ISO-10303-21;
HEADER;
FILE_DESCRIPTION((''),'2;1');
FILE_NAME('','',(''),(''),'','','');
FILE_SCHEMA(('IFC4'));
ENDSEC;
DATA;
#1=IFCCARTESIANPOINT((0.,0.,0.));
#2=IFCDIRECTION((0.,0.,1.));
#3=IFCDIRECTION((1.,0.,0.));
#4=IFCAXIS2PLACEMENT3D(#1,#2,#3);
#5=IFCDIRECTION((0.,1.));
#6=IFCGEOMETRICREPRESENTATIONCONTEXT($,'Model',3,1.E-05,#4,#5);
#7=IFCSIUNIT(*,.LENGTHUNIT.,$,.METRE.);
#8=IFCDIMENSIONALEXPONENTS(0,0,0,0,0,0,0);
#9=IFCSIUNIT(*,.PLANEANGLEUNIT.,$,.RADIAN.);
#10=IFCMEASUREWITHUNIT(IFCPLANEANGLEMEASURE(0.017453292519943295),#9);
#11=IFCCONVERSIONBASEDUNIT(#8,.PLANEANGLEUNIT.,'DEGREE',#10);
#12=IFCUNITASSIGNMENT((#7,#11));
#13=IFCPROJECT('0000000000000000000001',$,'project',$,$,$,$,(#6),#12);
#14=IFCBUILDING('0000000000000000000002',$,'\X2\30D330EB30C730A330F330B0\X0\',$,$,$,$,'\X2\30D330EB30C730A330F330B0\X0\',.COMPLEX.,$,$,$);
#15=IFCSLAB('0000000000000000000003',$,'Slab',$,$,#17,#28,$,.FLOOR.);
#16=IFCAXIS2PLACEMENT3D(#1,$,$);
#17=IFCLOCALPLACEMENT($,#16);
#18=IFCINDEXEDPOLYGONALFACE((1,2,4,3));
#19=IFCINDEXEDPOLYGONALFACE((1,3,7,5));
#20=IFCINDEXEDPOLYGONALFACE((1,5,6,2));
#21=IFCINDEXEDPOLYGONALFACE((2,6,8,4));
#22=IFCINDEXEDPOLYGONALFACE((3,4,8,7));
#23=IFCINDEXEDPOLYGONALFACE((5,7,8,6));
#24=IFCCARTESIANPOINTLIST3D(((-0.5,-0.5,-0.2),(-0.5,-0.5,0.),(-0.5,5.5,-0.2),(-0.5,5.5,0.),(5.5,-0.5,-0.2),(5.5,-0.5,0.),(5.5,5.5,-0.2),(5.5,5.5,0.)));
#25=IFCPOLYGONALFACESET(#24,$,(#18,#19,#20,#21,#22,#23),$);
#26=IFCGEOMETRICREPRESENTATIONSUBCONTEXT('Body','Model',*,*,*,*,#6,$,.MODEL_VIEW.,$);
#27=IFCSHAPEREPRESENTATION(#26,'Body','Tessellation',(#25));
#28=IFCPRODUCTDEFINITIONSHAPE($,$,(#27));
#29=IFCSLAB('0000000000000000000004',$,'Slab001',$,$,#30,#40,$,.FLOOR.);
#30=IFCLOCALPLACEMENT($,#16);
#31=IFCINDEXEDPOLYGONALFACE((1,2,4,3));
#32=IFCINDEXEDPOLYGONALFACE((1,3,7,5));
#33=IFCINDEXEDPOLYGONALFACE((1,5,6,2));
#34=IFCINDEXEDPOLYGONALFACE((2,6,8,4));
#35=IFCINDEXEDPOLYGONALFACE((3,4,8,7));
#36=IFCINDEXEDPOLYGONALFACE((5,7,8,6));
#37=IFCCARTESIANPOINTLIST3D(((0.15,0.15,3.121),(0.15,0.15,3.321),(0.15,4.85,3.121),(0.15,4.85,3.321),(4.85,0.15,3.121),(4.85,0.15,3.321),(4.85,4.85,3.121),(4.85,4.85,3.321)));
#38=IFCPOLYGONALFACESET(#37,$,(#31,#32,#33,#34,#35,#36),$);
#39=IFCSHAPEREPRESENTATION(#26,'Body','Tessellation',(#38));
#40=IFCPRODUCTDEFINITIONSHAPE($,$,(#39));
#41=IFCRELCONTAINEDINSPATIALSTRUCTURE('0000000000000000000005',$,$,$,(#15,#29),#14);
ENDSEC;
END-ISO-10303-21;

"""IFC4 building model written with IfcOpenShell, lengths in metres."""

from ifc_helpers import new_model, entity, si_unit, converted_unit, direction, frame, origin_with_axes, origin_2d_with_axis, place, context, subcontext, project, spatial, rectangle, extrude, element, save


model = new_model("IFC4")

# Units and contexts
model_context = context("Model", 3, precision=1e-05, world=origin_with_axes(), true_north=direction((0.0, 1.0)))
body_context = subcontext(model_context, "Body", "Model", "MODEL_VIEW")
ifc_project = project(units=[si_unit("LENGTHUNIT", "METRE"), converted_unit("PLANEANGLEUNIT", "DEGREE", entity("IfcPlaneAngleMeasure", 0.017453292519943295), si_unit("PLANEANGLEUNIT", "RADIAN"), dimensions=[0, 0, 0, 0, 0, 0, 0])], contexts=[model_context])

# Building
building = spatial("IfcBuilding", Name="ビルディング", LongName="ビルディング", CompositionType="COMPLEX")

# Slabs
placement = place(None, origin_with_axes())
element("IfcSlab", 1, at=placement, inside=building, Name="Slab", PredefinedType="FLOOR", context=body_context, shape_type="SweptSolid", body=[
    extrude(rectangle(XDim=6.0, YDim=6.0, at=origin_2d_with_axis()), frame((2.5, 2.5, -0.2), z_axis=(0.0, 0.0, 1.0), x_axis=(1.0, 0.0, 0.0)), (0.0, 0.0, 1.0), 0.2),
])
element("IfcSlab", 2, at=placement, inside=building, Name="Slab001", PredefinedType="FLOOR", context=body_context, shape_type="SweptSolid", body=[
    extrude(rectangle(XDim=4.7, YDim=4.7, at=origin_2d_with_axis()), frame((2.5, 2.5, 3.321), z_axis=(0.0, 0.0, 1.0), x_axis=(1.0, 0.0, 0.0)), (0.0, 0.0, -1.0), 0.2),
])

save(model, "model.ifc")
